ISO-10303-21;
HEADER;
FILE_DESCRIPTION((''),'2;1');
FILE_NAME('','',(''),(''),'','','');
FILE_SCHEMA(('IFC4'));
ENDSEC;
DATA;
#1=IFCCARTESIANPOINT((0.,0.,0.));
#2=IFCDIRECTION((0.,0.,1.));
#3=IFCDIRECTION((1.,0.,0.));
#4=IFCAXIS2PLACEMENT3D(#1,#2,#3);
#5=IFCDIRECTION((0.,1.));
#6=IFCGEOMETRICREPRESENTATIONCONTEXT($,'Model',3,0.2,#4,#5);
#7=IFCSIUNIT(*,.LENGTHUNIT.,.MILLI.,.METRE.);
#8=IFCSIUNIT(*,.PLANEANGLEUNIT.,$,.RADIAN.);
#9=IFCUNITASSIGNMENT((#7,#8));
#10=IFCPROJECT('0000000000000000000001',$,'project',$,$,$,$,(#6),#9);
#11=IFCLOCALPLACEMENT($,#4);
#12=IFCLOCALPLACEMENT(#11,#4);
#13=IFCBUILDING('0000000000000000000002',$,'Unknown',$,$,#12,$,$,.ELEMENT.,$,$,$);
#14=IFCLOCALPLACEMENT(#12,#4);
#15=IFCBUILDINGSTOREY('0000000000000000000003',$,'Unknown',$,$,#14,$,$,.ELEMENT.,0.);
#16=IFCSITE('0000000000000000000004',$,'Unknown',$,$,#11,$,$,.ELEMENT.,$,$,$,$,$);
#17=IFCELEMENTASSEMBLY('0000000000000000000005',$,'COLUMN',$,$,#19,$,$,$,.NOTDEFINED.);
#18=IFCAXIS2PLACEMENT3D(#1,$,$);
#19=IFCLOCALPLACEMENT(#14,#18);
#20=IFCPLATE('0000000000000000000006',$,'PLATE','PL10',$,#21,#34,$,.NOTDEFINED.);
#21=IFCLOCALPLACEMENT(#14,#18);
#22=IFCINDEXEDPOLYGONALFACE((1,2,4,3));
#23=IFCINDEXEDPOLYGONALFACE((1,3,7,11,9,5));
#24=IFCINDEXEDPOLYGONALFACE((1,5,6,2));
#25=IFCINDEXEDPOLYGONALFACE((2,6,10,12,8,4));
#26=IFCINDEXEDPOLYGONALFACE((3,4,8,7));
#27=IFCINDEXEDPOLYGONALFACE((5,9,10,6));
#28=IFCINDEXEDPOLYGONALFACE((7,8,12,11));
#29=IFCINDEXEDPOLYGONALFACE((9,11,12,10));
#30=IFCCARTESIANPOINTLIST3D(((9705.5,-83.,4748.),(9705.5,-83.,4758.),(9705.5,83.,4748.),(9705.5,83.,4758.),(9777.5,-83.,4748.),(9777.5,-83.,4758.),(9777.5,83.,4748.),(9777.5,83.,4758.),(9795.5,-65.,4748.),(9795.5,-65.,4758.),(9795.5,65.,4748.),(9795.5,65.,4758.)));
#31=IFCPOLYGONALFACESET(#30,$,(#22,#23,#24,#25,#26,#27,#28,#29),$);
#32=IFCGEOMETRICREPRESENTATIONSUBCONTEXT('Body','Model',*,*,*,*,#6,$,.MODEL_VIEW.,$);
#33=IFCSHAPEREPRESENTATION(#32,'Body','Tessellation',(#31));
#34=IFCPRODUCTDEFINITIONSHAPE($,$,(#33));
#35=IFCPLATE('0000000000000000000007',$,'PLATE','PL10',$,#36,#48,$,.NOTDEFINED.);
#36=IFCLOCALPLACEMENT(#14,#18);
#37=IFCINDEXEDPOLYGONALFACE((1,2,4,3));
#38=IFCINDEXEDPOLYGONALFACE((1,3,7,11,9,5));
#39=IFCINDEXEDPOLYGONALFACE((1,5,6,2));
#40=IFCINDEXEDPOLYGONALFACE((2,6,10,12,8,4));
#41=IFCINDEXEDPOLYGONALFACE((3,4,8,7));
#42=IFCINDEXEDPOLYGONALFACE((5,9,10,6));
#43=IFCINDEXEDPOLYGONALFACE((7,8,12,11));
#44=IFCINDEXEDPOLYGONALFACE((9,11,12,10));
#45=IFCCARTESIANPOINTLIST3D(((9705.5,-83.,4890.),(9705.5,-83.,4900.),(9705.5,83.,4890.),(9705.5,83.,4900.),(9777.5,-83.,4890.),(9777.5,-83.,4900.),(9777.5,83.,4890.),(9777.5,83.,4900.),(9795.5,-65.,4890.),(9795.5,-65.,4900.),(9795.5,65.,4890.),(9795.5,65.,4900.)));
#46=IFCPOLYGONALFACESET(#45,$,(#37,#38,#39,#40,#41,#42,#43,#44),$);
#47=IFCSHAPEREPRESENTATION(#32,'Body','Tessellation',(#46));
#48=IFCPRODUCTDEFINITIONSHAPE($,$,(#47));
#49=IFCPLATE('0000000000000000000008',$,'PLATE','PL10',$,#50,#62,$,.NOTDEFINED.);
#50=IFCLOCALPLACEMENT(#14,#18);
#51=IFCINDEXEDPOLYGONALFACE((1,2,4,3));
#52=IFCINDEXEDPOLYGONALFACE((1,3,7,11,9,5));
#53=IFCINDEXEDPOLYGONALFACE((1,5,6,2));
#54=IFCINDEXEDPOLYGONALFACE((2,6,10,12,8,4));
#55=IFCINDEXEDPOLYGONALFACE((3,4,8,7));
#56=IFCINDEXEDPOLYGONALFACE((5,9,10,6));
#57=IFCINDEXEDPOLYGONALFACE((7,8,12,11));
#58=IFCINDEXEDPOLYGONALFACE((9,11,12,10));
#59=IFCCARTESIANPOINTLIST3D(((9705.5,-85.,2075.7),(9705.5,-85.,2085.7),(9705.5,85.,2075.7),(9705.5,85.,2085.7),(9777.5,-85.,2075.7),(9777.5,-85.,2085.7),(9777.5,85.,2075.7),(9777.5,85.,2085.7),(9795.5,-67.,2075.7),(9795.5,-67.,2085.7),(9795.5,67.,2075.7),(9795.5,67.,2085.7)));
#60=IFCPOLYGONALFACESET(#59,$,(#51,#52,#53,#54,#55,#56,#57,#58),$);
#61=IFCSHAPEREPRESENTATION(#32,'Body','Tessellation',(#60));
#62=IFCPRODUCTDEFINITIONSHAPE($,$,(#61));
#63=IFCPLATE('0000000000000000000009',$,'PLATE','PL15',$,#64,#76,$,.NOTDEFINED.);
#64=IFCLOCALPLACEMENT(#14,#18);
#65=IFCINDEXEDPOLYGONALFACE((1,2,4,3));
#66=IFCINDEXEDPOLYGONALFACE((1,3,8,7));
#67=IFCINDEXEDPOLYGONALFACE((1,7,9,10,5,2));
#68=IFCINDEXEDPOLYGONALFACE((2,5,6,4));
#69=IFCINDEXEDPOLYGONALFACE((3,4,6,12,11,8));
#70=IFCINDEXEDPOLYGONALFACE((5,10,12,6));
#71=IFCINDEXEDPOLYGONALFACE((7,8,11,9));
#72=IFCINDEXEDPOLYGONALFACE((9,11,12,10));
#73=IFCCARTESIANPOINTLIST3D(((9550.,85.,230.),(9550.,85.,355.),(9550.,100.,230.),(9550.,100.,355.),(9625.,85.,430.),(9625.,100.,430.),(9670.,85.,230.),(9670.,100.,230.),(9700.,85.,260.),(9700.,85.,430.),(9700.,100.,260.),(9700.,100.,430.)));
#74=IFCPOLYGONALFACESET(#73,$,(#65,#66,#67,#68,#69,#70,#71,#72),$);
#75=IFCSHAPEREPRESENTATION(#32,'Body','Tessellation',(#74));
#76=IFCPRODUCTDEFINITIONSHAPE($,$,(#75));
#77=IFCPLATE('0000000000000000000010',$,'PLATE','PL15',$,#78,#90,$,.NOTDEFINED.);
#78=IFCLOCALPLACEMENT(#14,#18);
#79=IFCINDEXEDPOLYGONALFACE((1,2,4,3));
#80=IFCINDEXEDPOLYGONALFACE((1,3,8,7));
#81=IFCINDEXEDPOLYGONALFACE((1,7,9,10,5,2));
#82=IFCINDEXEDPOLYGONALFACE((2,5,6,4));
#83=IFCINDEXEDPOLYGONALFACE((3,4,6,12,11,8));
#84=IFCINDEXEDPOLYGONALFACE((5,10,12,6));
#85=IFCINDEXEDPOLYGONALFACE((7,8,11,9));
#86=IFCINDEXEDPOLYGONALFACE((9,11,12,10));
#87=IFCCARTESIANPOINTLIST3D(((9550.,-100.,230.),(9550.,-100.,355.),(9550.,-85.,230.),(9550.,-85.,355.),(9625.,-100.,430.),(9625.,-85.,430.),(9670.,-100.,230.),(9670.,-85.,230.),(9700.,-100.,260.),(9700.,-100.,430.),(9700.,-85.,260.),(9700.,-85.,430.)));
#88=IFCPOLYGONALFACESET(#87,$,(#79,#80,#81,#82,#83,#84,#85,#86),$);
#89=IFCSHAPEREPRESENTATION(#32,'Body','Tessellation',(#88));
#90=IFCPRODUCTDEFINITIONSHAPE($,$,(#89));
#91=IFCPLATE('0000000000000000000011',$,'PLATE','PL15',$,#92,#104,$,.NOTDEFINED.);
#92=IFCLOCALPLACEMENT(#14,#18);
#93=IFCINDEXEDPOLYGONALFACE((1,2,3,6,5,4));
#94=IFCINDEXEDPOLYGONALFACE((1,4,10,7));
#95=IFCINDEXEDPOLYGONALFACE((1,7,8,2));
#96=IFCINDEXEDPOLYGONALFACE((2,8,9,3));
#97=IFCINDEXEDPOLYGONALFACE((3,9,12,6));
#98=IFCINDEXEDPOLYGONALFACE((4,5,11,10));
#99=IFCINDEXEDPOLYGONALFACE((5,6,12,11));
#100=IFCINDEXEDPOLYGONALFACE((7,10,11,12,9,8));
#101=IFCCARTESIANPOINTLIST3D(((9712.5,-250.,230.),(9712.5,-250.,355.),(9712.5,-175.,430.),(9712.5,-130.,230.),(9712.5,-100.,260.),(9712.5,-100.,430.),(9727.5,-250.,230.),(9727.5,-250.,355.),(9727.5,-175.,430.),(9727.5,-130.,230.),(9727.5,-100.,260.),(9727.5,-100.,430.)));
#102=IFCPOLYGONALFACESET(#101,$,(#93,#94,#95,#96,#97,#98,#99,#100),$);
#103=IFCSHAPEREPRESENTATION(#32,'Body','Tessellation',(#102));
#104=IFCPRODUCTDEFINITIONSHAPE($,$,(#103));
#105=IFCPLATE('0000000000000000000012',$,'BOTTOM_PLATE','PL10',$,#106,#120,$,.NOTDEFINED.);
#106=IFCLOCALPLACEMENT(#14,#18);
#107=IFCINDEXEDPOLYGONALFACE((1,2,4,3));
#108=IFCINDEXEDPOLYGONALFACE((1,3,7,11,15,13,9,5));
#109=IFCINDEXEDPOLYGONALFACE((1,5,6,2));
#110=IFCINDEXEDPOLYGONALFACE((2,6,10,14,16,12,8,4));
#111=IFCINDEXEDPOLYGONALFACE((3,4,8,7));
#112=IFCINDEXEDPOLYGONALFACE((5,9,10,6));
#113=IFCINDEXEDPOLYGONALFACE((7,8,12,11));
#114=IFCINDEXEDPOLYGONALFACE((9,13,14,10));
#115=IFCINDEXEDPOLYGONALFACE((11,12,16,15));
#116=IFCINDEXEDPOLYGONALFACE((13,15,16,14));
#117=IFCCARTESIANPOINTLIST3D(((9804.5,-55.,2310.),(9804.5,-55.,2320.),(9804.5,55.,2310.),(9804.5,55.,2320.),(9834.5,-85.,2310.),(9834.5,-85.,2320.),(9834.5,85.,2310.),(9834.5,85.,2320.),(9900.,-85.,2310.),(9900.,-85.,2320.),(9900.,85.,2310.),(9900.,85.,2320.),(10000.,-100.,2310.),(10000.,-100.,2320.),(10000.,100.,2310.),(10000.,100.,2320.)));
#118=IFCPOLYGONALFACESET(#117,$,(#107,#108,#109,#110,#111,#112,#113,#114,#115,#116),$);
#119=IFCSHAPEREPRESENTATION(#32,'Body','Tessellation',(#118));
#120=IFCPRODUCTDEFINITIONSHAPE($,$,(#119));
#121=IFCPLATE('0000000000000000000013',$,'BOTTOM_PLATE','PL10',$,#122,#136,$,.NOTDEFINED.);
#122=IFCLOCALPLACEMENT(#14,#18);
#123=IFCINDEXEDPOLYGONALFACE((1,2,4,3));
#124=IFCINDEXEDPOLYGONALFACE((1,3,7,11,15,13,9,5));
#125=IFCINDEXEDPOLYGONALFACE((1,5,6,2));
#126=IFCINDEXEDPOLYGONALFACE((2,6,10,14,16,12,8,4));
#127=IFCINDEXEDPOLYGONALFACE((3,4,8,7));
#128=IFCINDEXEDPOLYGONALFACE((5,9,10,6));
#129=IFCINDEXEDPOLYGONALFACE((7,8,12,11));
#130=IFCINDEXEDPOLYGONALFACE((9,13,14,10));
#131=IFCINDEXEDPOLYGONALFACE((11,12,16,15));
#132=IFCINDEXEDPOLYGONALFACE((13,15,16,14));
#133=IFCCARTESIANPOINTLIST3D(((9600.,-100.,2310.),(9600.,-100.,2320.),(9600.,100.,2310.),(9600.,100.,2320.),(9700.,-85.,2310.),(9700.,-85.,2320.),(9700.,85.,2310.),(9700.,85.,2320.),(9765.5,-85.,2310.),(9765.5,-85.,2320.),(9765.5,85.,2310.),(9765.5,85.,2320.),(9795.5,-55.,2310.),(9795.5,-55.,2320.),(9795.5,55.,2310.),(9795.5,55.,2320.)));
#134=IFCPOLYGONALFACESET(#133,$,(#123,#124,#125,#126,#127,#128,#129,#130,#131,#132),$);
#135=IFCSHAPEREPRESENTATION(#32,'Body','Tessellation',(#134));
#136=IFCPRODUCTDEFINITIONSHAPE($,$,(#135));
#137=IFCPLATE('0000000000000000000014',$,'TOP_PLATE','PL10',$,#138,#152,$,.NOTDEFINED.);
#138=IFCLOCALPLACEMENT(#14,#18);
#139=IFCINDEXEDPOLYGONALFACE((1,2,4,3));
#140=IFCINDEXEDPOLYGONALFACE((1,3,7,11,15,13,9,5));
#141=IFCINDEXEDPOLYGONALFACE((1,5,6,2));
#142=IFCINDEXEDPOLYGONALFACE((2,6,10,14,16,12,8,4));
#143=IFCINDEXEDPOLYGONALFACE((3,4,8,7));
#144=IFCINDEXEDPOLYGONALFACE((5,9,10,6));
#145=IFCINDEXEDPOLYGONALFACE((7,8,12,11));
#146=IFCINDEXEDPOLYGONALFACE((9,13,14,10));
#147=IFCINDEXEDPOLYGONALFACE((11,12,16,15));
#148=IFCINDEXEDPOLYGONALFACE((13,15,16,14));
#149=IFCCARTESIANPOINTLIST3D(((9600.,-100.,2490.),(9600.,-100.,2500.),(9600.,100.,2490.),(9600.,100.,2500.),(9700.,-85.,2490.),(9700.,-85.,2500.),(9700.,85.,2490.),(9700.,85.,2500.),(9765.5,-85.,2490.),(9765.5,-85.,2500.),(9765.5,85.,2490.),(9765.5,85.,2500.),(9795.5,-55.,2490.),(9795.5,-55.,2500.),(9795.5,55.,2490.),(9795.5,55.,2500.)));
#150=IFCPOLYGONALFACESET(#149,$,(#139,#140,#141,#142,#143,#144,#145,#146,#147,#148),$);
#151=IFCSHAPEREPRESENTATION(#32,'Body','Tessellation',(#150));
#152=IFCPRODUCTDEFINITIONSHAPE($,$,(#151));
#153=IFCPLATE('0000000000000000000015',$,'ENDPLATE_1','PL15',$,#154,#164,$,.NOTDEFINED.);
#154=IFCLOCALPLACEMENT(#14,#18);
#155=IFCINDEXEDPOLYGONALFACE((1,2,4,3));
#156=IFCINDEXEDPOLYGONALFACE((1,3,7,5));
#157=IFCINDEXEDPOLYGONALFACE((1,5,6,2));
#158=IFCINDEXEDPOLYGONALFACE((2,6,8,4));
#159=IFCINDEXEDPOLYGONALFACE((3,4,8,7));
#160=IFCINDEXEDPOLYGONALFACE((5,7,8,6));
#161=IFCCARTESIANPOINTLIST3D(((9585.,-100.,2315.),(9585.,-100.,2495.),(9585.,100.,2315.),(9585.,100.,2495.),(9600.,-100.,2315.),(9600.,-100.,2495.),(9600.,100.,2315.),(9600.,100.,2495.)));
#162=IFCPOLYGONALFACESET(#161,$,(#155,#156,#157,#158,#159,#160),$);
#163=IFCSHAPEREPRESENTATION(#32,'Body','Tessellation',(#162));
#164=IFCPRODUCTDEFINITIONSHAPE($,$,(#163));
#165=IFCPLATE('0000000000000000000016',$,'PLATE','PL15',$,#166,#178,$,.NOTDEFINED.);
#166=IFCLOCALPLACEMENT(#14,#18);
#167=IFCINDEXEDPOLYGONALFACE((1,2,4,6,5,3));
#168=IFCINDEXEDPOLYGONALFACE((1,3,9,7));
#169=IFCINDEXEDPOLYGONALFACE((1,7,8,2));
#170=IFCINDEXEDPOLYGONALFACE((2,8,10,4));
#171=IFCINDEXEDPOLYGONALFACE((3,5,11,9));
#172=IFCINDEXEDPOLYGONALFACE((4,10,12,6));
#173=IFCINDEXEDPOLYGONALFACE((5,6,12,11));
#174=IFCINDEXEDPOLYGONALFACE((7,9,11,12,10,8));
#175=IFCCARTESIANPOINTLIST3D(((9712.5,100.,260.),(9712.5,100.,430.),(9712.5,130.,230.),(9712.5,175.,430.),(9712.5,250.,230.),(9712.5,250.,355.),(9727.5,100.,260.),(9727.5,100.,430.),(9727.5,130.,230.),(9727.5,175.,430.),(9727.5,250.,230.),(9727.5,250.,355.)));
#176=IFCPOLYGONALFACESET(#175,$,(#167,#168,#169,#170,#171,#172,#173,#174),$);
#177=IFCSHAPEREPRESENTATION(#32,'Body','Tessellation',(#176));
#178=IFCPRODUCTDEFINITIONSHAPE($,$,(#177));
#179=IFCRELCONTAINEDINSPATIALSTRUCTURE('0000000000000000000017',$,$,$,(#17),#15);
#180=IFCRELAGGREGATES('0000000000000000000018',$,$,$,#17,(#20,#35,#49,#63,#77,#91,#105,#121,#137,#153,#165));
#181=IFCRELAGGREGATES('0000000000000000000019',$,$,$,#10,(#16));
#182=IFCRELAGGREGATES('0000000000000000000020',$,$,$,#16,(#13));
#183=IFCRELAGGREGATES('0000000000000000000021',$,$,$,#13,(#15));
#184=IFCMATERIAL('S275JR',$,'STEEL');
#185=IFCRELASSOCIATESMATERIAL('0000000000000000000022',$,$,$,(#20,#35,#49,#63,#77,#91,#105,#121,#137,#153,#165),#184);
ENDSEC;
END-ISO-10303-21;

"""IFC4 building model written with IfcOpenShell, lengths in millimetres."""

from ifc_helpers import new_model, si_unit, direction, frame, origin_with_axes, place, context, subcontext, project, spatial, line, indexed_curve, outline, extrude, material, element, aggregate, save


model = new_model("IFC4")

# Units and contexts
model_context = context("Model", 3, precision=0.2, world=origin_with_axes(), true_north=direction((0.0, 1.0)))
body_context = subcontext(model_context, "Body", "Model", "MODEL_VIEW")
ifc_project = project(units=[si_unit("LENGTHUNIT", "METRE", prefix="MILLI"), si_unit("PLANEANGLEUNIT", "RADIAN")], contexts=[model_context])

# Site, building, storey
site_placement = place(None, origin_with_axes())
site = spatial("IfcSite", under=ifc_project, at=site_placement, Name="Unknown", CompositionType="ELEMENT")
building_placement = place(site_placement, origin_with_axes())
building = spatial("IfcBuilding", under=site, at=building_placement, Name="Unknown", CompositionType="ELEMENT")
storey_placement = place(building_placement, origin_with_axes())
storey = spatial("IfcBuildingStorey", under=building, at=storey_placement, Name="Unknown", CompositionType="ELEMENT", Elevation=0.0)

# Shared definitions
ifc_material_1 = material(Name="S275JR", Category="STEEL")

# Element assembly
assembly_1_placement = place(storey_placement, frame((9800.0, 0.0, 200.0), z_axis=(-1.0, 0.0, 0.0), x_axis=(0.0, 0.0, 1.0)))
assembly_1 = element("IfcElementAssembly", 1, at=assembly_1_placement, inside=storey, Name="COLUMN", PredefinedType="NOTDEFINED")

# Plates
plate_1_placement = place(assembly_1_placement, frame((4553.0, 83.0, 94.5), z_axis=(-1.0, 0.0, 0.0), x_axis=(0.0, -0.000002, -1.0)))
plate_1 = element("IfcPlate", 2, at=plate_1_placement, material=ifc_material_1, Name="PLATE", Description="PL10", PredefinedType="NOTDEFINED", context=body_context, shape_type="SolidModel", body=[
    extrude(outline(indexed_curve([(0.0, 0.0), (72.0, 0.0), (90.0, 18.0), (90.0, 148.0), (72.0, 166.0), (0.0, 166.0)], segments=[line(1, 2, 3, 4, 5, 6, 1)])), frame((0.0, 0.0, 5.0), z_axis=(0.0, 0.0, 1.0), x_axis=(1.0, 0.0, 0.0)), (0.0, -0.000002, -1.0), 10.0),
])
plate_2_placement = place(assembly_1_placement, frame((4695.0, 83.0, 94.5), z_axis=(-1.0, 0.0, 0.0), x_axis=(0.0, -0.000002, -1.0)))
plate_2 = element("IfcPlate", 3, at=plate_2_placement, material=ifc_material_1, Name="PLATE", Description="PL10", PredefinedType="NOTDEFINED", context=body_context, shape_type="SolidModel", body=[
    extrude(outline(indexed_curve([(0.0, 0.0), (72.0, 0.0), (90.0, 18.0), (90.0, 148.0), (72.0, 166.0), (0.0, 166.0)], segments=[line(1, 2, 3, 4, 5, 6, 1)])), frame((0.0, 0.0, 5.0), z_axis=(0.0, 0.0, 1.0), x_axis=(1.0, 0.0, 0.0)), (0.0, -0.000002, -1.0), 10.0),
])
plate_3_placement = place(assembly_1_placement, frame((1880.7, 85.0, 94.5), z_axis=(-1.0, 0.0, 0.0), x_axis=(0.0, -0.000002, -1.0)))
plate_3 = element("IfcPlate", 4, at=plate_3_placement, material=ifc_material_1, Name="PLATE", Description="PL10", PredefinedType="NOTDEFINED", context=body_context, shape_type="SolidModel", body=[
    extrude(outline(indexed_curve([(0.0, 0.0), (72.0, 0.0), (90.0, 18.0), (90.0, 152.0), (72.0, 170.0), (0.0, 170.0)], segments=[line(1, 2, 3, 4, 5, 6, 1)])), frame((0.0, 0.0, 5.0), z_axis=(0.0, 0.0, 1.0), x_axis=(1.0, 0.0, 0.0)), (0.0, -0.000002, -1.0), 10.0),
])
plate_4_placement = place(assembly_1_placement, frame((60.0, 92.5, 100.0), z_axis=(0.0, 1.0, 0.0), x_axis=(-0.707107, 0.0, 0.707107)))
plate_4 = element("IfcPlate", 5, at=plate_4_placement, material=ifc_material_1, Name="PLATE", Description="PL15", PredefinedType="NOTDEFINED", context=body_context, shape_type="SolidModel", body=[
    extrude(outline(indexed_curve([(0.0, 0.0), (42.4, 0.0), (127.3, 84.9), (38.9, 173.2), (-67.2, 173.2), (-120.2, 120.2)], segments=[line(1, 2, 3, 4, 5, 6, 1)])), frame((0.0, 0.0, 7.5), z_axis=(0.0, 0.0, 1.0), x_axis=(1.0, 0.0, 0.0)), (0.0, -0.000002, -1.0), 15.0),
])
plate_5_placement = place(assembly_1_placement, frame((60.0, -92.5, 100.0), z_axis=(0.0, 1.0, 0.0), x_axis=(-0.707107, 0.0, 0.707107)))
plate_5 = element("IfcPlate", 6, at=plate_5_placement, material=ifc_material_1, Name="PLATE", Description="PL15", PredefinedType="NOTDEFINED", context=body_context, shape_type="SolidModel", body=[
    extrude(outline(indexed_curve([(0.0, 0.0), (42.4, 0.0), (127.3, 84.9), (38.9, 173.2), (-67.2, 173.2), (-120.2, 120.2)], segments=[line(1, 2, 3, 4, 5, 6, 1)])), frame((0.0, 0.0, 7.5), z_axis=(0.0, 0.0, 1.0), x_axis=(1.0, 0.0, 0.0)), (0.0, -0.000002, -1.0), 15.0),
])
plate_6_placement = place(assembly_1_placement, frame((60.0, -100.0, 80.0), z_axis=(0.0, 0.0, 1.0), x_axis=(-0.707116, -0.707097, 0.0)))
plate_6 = element("IfcPlate", 7, at=plate_6_placement, material=ifc_material_1, Name="PLATE", Description="PL15", PredefinedType="NOTDEFINED", context=body_context, shape_type="SolidModel", body=[
    extrude(outline(indexed_curve([(0.0, 0.0), (42.4, 0.0), (127.3, 84.9), (38.9, 173.2), (-67.2, 173.2), (-120.2, 120.2)], segments=[line(1, 2, 3, 4, 5, 6, 1)])), frame((0.0, 0.0, 7.5), z_axis=(0.0, 0.0, 1.0), x_axis=(1.0, 0.0, 0.0)), (0.0, -0.000002, -1.0), 15.0),
])
plate_7_placement = place(assembly_1_placement, frame((2115.0, 85.0, -4.5), z_axis=(1.0, 0.0, 0.0), x_axis=(-0.000002, -1.0, 0.0)))
plate_7 = element("IfcPlate", 8, at=plate_7_placement, material=ifc_material_1, Name="BOTTOM_PLATE", Description="PL10", PredefinedType="NOTDEFINED", context=body_context, shape_type="SolidModel", body=[
    extrude(outline(indexed_curve([(0.0, 30.0), (30.0, 0.0), (140.0, 0.0), (170.0, 30.0), (170.0, 95.5), (185.0, 195.5), (-15.0, 195.5), (0.0, 95.5)], segments=[line(1, 2, 3, 4, 5, 6, 7, 8, 1)])), frame((0.0, 0.0, 5.0), z_axis=(0.0, 0.0, 1.0), x_axis=(1.0, 0.0, 0.0)), (0.0, -0.000002, -1.0), 10.0),
])
plate_8_placement = place(assembly_1_placement, frame((2115.0, -85.0, 4.5), z_axis=(1.0, 0.0, 0.0), x_axis=(0.0, 1.0, 0.0)))
plate_8 = element("IfcPlate", 9, at=plate_8_placement, material=ifc_material_1, Name="BOTTOM_PLATE", Description="PL10", PredefinedType="NOTDEFINED", context=body_context, shape_type="SolidModel", body=[
    extrude(outline(indexed_curve([(0.0, 30.0), (30.0, 0.0), (140.0, 0.0), (170.0, 30.0), (170.0, 95.5), (185.0, 195.5), (-15.0, 195.5), (0.0, 95.5)], segments=[line(1, 2, 3, 4, 5, 6, 7, 8, 1)])), frame((0.0, 0.0, 5.0), z_axis=(0.0, 0.0, 1.0), x_axis=(1.0, 0.0, 0.0)), (0.0, -0.000002, -1.0), 10.0),
])
plate_9_placement = place(assembly_1_placement, frame((2295.0, -85.0, 100.0), z_axis=(1.0, 0.0, 0.0), x_axis=(0.0, -0.000002, -1.0)))
plate_9 = element("IfcPlate", 10, at=plate_9_placement, material=ifc_material_1, Name="TOP_PLATE", Description="PL10", PredefinedType="NOTDEFINED", context=body_context, shape_type="SolidModel", body=[
    extrude(outline(indexed_curve([(0.0, 0.0), (65.5, 0.0), (95.5, 30.0), (95.5, 140.0), (65.5, 170.0), (0.0, 170.0), (-100.0, 185.0), (-100.0, -15.0)], segments=[line(1, 2, 3, 4, 5, 6, 7, 8, 1)])), frame((0.0, 0.0, 5.0), z_axis=(0.0, 0.0, 1.0), x_axis=(1.0, 0.0, 0.0)), (0.0, -0.000002, -1.0), 10.0),
])
plate_10_placement = place(assembly_1_placement, frame((2115.0, -100.0, 207.5), z_axis=(0.0, 0.0, 1.0), x_axis=(1.0, 0.0, 0.0)))
plate_10 = element("IfcPlate", 11, at=plate_10_placement, material=ifc_material_1, Name="ENDPLATE_1", Description="PL15", PredefinedType="NOTDEFINED", context=body_context, shape_type="SolidModel", body=[
    extrude(outline(indexed_curve([(0.0, 0.0), (180.0, 0.0), (180.0, 200.0), (0.0, 200.0)], segments=[line(1, 2, 3, 4, 1)])), frame((0.0, 0.0, 7.5), z_axis=(0.0, 0.0, 1.0), x_axis=(1.0, 0.0, 0.0)), (0.0, -0.000002, -1.0), 15.0),
])
plate_11_placement = place(assembly_1_placement, frame((60.0, 100.0, 80.0), z_axis=(0.0, -0.000002, -1.0), x_axis=(-0.707113, 0.707101, 0.0)))
plate_11 = element("IfcPlate", 12, at=plate_11_placement, material=ifc_material_1, Name="PLATE", Description="PL15", PredefinedType="NOTDEFINED", context=body_context, shape_type="SolidModel", body=[
    extrude(outline(indexed_curve([(0.0, 0.0), (42.4, 0.0), (127.3, 84.9), (38.9, 173.2), (-67.2, 173.2), (-120.2, 120.2)], segments=[line(1, 2, 3, 4, 5, 6, 1)])), frame((0.0, 0.0, 7.5), z_axis=(0.0, 0.0, 1.0), x_axis=(1.0, 0.0, 0.0)), (0.0, -0.000002, -1.0), 15.0),
])

aggregate(assembly_1, [plate_1, plate_2, plate_3, plate_4, plate_5, plate_6, plate_7, plate_8, plate_9, plate_10, plate_11])

save(model, "model.ifc")
